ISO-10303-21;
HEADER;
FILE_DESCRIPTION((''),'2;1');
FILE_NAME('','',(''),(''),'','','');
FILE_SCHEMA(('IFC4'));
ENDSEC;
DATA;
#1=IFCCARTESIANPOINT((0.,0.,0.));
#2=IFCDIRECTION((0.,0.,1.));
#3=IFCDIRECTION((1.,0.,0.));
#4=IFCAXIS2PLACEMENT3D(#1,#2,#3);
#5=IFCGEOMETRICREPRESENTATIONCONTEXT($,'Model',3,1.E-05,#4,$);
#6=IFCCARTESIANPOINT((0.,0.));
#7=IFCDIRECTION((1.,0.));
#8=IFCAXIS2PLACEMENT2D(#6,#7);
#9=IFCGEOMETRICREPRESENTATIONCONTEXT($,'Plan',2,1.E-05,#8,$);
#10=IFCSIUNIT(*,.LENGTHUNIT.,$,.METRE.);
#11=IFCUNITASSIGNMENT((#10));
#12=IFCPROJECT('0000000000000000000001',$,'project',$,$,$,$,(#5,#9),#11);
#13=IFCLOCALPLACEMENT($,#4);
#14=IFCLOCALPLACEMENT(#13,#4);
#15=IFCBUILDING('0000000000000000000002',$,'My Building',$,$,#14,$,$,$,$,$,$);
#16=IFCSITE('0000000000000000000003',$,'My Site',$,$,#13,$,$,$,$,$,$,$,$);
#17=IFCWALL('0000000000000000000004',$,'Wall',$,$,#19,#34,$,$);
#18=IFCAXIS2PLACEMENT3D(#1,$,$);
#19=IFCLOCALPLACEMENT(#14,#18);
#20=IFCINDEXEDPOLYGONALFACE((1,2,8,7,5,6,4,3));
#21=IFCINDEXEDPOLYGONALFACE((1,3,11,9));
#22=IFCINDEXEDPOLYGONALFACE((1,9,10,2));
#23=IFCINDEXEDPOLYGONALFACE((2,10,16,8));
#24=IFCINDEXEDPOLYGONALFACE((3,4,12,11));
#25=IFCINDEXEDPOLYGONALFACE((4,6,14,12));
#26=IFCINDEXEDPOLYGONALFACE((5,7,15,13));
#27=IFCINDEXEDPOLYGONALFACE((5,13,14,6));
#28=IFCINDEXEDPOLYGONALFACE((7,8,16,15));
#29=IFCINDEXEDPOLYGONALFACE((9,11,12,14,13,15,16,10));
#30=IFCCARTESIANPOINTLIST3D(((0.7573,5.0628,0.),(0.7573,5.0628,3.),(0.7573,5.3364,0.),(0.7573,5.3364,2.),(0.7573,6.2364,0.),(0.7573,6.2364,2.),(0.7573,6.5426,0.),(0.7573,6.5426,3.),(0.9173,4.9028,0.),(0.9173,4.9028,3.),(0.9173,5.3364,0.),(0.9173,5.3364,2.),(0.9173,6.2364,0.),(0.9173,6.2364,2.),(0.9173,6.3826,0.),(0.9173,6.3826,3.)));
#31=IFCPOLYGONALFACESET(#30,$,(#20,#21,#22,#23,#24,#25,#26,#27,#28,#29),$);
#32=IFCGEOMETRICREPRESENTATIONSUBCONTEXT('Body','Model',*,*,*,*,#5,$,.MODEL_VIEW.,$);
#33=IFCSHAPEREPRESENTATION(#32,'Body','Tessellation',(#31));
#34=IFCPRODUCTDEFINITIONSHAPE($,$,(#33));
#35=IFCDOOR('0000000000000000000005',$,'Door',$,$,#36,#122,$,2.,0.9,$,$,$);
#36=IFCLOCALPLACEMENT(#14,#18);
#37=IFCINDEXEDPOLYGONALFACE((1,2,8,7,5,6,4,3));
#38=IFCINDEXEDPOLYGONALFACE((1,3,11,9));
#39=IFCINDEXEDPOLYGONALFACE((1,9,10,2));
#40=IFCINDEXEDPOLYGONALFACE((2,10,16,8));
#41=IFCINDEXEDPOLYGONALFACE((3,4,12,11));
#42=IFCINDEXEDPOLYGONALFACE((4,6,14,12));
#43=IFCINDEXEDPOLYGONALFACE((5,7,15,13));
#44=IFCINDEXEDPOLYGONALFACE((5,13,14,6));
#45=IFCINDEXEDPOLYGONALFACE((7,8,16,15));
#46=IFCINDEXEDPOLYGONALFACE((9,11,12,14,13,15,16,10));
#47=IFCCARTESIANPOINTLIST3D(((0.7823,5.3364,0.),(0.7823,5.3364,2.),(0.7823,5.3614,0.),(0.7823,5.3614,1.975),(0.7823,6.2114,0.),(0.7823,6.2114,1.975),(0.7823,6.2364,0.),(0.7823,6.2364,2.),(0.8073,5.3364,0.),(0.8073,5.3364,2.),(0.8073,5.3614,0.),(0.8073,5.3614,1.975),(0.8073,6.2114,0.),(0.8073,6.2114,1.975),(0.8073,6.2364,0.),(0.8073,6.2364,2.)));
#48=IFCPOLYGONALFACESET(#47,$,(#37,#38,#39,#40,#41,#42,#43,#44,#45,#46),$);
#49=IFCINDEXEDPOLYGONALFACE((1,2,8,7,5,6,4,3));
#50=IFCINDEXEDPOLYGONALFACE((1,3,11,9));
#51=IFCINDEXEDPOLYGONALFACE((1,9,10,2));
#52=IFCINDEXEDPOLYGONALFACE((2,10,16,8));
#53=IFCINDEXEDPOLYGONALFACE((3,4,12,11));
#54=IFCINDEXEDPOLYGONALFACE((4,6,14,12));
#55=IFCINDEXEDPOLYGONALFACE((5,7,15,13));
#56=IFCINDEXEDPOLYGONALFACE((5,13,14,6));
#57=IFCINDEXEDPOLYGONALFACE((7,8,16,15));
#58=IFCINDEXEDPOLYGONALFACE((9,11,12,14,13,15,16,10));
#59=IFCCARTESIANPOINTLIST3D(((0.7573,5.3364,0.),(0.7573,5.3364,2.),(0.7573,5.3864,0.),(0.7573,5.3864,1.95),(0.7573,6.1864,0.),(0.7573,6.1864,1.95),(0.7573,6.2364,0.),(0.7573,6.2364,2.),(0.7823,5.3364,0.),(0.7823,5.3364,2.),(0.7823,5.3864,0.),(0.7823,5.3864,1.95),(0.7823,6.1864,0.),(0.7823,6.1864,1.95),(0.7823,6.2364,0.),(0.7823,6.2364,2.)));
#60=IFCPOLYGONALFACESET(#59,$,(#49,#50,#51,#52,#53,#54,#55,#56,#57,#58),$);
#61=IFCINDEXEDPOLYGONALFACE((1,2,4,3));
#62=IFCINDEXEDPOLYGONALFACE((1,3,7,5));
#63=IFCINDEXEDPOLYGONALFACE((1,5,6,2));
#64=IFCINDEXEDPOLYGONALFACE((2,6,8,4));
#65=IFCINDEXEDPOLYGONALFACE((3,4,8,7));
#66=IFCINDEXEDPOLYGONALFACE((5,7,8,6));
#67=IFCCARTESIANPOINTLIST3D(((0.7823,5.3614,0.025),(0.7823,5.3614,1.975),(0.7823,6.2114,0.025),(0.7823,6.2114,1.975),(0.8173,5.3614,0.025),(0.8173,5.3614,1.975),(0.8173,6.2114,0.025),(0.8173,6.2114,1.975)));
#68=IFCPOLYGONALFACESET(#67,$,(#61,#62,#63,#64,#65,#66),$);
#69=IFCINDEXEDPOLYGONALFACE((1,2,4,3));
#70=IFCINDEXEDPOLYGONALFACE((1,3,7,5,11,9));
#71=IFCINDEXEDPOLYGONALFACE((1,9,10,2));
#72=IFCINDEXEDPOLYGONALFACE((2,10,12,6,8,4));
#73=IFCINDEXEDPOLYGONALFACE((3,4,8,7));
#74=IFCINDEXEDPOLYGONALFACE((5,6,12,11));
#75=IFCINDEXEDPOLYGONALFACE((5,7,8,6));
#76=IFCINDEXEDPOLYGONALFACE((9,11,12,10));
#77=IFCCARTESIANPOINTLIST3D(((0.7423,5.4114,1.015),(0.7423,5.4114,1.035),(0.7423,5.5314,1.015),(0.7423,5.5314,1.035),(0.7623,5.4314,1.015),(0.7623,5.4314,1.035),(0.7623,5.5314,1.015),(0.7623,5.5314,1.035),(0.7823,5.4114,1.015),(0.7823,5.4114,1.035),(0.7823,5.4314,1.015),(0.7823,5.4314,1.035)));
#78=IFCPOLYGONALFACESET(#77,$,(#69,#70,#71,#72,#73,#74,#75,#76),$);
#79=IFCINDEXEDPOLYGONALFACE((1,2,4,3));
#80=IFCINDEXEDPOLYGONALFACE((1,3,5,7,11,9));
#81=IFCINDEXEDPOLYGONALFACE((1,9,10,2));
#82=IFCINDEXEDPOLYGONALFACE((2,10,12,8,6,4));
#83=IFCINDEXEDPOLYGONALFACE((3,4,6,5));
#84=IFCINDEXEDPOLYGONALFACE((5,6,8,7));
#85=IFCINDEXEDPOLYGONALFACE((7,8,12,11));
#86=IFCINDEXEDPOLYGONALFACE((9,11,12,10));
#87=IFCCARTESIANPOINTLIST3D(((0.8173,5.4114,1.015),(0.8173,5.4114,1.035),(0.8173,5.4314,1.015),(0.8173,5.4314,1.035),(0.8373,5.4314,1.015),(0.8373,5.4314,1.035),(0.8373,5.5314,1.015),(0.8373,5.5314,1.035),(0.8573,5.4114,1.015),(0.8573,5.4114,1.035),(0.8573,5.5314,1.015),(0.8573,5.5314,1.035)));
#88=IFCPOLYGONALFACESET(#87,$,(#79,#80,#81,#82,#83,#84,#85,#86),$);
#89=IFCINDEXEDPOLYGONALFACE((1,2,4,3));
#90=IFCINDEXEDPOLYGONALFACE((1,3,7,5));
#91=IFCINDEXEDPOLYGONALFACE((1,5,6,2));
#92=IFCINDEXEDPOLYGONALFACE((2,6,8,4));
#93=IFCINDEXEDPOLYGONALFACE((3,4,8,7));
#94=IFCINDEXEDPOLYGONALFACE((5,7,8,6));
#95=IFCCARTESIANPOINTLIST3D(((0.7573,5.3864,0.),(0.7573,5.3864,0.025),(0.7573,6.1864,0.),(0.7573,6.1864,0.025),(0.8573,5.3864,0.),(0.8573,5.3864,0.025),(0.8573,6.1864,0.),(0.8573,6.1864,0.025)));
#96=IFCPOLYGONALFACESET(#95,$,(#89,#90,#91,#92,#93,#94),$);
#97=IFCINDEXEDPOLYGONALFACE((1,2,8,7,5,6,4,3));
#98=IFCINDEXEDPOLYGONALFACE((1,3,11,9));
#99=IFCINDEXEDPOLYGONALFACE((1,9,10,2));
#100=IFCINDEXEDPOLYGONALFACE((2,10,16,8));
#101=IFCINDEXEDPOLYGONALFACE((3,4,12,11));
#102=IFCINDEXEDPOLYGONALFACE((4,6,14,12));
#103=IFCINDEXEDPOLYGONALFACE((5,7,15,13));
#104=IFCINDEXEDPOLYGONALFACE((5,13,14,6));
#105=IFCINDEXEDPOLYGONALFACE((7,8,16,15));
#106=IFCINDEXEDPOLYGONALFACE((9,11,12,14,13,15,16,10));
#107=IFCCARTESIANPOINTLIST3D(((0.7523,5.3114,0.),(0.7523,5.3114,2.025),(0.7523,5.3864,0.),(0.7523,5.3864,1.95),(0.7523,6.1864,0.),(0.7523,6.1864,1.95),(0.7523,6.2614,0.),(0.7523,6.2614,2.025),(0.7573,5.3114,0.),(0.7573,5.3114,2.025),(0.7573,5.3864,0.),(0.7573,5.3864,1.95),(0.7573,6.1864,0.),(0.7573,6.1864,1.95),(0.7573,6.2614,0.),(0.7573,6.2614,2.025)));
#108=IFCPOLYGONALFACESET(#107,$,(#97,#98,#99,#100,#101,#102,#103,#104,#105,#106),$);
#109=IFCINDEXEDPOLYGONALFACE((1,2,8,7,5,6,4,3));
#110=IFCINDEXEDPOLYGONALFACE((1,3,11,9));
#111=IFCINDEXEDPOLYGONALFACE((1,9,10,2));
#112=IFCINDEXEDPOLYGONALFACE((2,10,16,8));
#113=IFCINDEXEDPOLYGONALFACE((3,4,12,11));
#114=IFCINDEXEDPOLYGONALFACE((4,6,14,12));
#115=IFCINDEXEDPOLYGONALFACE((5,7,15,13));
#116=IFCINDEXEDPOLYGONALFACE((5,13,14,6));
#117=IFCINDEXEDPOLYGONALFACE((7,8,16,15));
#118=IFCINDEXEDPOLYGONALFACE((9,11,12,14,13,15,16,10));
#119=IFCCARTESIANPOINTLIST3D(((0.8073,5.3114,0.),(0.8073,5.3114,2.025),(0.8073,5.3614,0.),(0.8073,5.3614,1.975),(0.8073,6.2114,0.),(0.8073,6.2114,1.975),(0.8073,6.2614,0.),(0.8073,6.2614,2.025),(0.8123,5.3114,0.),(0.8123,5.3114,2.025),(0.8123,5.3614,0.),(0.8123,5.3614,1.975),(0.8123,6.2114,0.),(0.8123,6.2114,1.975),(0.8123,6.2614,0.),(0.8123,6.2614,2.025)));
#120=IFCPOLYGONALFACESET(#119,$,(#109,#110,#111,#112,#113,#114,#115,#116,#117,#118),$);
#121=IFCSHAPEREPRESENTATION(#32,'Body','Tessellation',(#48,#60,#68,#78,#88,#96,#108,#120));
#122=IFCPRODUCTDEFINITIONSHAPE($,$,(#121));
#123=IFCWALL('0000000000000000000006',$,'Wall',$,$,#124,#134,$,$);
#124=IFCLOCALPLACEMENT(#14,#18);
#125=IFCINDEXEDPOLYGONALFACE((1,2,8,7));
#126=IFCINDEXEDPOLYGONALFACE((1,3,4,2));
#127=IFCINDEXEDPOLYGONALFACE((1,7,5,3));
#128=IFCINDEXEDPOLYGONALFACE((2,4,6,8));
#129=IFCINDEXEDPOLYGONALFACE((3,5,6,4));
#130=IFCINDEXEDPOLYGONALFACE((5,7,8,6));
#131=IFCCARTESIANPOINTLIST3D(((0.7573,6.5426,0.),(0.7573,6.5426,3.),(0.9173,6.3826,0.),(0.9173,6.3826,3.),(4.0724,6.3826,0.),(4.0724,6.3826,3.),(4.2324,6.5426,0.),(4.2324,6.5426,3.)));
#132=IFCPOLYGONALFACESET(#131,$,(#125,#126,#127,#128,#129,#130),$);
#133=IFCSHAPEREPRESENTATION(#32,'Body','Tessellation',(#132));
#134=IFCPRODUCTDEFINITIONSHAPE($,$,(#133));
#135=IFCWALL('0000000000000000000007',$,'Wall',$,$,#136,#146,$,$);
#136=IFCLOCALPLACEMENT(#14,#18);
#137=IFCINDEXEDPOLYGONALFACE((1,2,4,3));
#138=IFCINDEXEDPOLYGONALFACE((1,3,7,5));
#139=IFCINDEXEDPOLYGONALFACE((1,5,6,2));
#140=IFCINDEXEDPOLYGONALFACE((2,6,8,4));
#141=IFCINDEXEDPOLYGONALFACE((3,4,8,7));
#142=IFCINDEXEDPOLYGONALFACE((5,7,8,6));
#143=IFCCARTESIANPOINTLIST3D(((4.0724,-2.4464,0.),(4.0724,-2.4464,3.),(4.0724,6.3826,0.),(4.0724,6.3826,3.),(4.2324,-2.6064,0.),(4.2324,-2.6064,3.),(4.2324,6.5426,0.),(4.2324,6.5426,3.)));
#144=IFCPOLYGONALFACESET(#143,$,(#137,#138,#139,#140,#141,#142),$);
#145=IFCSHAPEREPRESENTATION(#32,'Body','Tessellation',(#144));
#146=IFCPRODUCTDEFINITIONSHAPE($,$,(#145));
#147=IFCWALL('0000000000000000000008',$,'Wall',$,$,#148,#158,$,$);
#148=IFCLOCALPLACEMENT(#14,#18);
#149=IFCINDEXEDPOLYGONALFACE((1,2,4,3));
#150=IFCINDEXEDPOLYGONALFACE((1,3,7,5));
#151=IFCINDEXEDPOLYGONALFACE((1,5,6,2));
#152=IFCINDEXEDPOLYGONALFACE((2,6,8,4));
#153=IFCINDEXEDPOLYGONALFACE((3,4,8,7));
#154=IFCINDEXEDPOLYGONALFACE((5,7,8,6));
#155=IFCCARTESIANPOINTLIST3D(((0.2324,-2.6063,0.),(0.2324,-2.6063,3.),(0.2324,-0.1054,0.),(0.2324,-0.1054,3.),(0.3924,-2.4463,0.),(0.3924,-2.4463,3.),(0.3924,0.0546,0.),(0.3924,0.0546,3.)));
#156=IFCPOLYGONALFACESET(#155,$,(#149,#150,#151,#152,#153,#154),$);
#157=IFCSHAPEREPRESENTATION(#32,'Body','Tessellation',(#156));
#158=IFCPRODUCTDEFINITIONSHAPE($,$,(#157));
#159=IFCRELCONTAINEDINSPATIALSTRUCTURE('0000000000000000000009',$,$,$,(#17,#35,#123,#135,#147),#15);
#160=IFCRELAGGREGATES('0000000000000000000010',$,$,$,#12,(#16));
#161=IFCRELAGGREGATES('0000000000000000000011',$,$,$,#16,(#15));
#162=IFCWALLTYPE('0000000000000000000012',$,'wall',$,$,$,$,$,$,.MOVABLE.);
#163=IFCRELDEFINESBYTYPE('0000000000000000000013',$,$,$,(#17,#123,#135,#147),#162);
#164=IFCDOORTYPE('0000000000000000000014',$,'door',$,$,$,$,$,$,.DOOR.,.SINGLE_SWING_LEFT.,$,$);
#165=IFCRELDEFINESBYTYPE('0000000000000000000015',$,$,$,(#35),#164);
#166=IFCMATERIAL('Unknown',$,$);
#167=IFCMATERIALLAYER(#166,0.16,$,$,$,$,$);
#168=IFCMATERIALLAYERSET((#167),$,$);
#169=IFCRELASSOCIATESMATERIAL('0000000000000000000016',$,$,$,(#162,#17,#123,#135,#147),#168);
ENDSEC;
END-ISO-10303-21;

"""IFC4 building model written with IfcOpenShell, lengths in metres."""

from ifc_helpers import new_model, entity, si_unit, frame, origin_with_axes, origin_2d_with_axis, place, context, subcontext, project, spatial, line, indexed_curve, outline, extrude, shape, source, transform, mapped, material, layer, layer_set, layer_usage, type_object, type_shapes, element, fill, save


model = new_model("IFC4")

# Units and contexts
model_context = context("Model", 3, precision=1e-05, world=origin_with_axes())
plan_context = context("Plan", 2, precision=1e-05, world=origin_2d_with_axis())
body_context_1 = subcontext(model_context, "Body", "Model", "MODEL_VIEW")
body_context_2 = subcontext(plan_context, "Body", "Plan", "PLAN_VIEW")
ifc_project = project(units=[si_unit("LENGTHUNIT", "METRE")], contexts=[model_context, plan_context])

# Site, building
site_placement = place(None, origin_with_axes())
site = spatial("IfcSite", under=ifc_project, at=site_placement, Name="My Site")
building_placement = place(site_placement, origin_with_axes())
building = spatial("IfcBuilding", under=site, at=building_placement, Name="My Building")

# Shared definitions
ifc_material = material(Name="Unknown")

# Shared definitions
ifc_layer_1 = layer(ifc_material, 0.16)
ifc_layer_set_1 = layer_set([ifc_layer_1])
wall_type_1 = type_object("IfcWallType", Name="wall", PredefinedType="MOVABLE", material=ifc_layer_set_1)

# Wall, opening, door
ifc_layer_usage_1 = layer_usage(ifc_layer_set_1, "AXIS2", "POSITIVE", 0.0)
wall_1_placement = place(building_placement, frame((0.9173, 4.9028, 0.0), z_axis=(0.0, 0.0, 1.0), x_axis=(0.0, 1.0, 0.0)))
wall_1 = element("IfcWall", 1, at=wall_1_placement, inside=building, type_object=wall_type_1, material=ifc_layer_usage_1, Name="Wall", context=body_context_1, shape_type="SweptSolid", body=[
    extrude(outline(indexed_curve([(0.0, 0.0), (0.16, 0.16), (1.6398, 0.16), (1.4798, 0.0)], segments=[line(1, 2, 3, 4, 1)])), origin_with_axes(), (0.0, 0.0, 1.0), 3.0),
])
shared_shape_1 = source(origin_with_axes(), body_context_1, "Body", "SweptSolid", [
    extrude(outline(indexed_curve([(0.0, 0.0), (0.9, 0.0), (0.9, 2.0), (0.0, 2.0)], segments=[line(1, 2, 3, 4, 1)])), frame((0.0, -0.6, 0.0), z_axis=(0.0, -1.0, 0.0), x_axis=(1.0, 0.0, 0.0)), (0.0, 0.0, -1.0), 1.2),
])
opening_1_placement = place(wall_1_placement, frame((1.3336, 0.16, 0.0), z_axis=(0.0, 0.0, 1.0), x_axis=(-1.0, 0.0, 0.0)))
opening_1 = element("IfcOpeningElement", 2, at=opening_1_placement, cuts=wall_1, PredefinedType="OPENING", context=body_context_1, shape_type="MappedRepresentation", body=[
    mapped(shared_shape_1, transform((0.0, 0.0, 0.0), x_axis=(1.0, 0.0, 0.0), y_axis=(0.0, 1.0, 0.0), z_axis=(0.0, 0.0, 1.0), scale=1.0)),
])
door_type = type_object("IfcDoorType", Name="door", OperationType="SINGLE_SWING_LEFT", PredefinedType="DOOR")
shared_shape_2 = source(origin_with_axes(), body_context_1, "Body", "SweptSolid", [
    extrude(outline(indexed_curve([(0.0, 0.0), (0.0, 2.0), (0.9, 2.0), (0.9, 0.0), (0.875, 0.0), (0.875, 1.975), (0.025, 1.975), (0.025, 0.0)], segments=[line(1, 2, 3, 4, 5, 6, 7, 8, 1)])), frame((0.0, 0.025, 0.0), z_axis=(0.0, -1.0, 0.0), x_axis=(1.0, 0.0, 0.0)), (0.0, 0.0, -1.0), 0.025),
    extrude(outline(indexed_curve([(0.0, 0.0), (0.0, 2.0), (0.9, 2.0), (0.9, 0.0), (0.85, 0.0), (0.85, 1.95), (0.05, 1.95), (0.05, 0.0)], segments=[line(1, 2, 3, 4, 5, 6, 7, 8, 1)])), frame((0.0, 0.0, 0.0), z_axis=(0.0, -1.0, 0.0), x_axis=(1.0, 0.0, 0.0)), (0.0, 0.0, -1.0), 0.025),
    extrude(outline(indexed_curve([(0.0, 0.0), (0.85, 0.0), (0.85, 0.035), (0.0, 0.035)], segments=[line(1, 2, 3, 4, 1)])), frame((0.025, 0.025, 0.025), z_axis=(0.0, 0.0, 1.0), x_axis=(1.0, 0.0, 0.0)), (0.0, 0.0, 1.0), 1.95),
    extrude(outline(indexed_curve([(0.0, 0.0), (0.0, -0.04), (-0.12, -0.04), (-0.12, -0.02), (-0.02, -0.02), (-0.02, 0.0)], segments=[line(1, 2, 3, 4, 5, 6, 1)])), frame((0.825, 0.025, 1.015), z_axis=(0.0, 0.0, 1.0), x_axis=(1.0, 0.0, 0.0)), (0.0, 0.0, 1.0), 0.02),
    extrude(outline(indexed_curve([(0.0, 0.0), (0.0, 0.04), (-0.12, 0.04), (-0.12, 0.02), (-0.02, 0.02), (-0.02, 0.0)], segments=[line(1, 2, 3, 4, 5, 6, 1)])), frame((0.825, 0.06, 1.015), z_axis=(0.0, 0.0, 1.0), x_axis=(1.0, 0.0, 0.0)), (0.0, 0.0, 1.0), 0.02),
    extrude(outline(indexed_curve([(0.0, 0.0), (0.8, 0.0), (0.8, 0.1), (0.0, 0.1)], segments=[line(1, 2, 3, 4, 1)])), frame((0.05, 0.0, 0.0), z_axis=(0.0, 0.0, 1.0), x_axis=(1.0, 0.0, 0.0)), (0.0, 0.0, 1.0), 0.025),
    extrude(outline(indexed_curve([(0.0, 0.0), (0.0, 2.025), (0.95, 2.025), (0.95, 0.0), (0.875, 0.0), (0.875, 1.95), (0.075, 1.95), (0.075, 0.0)], segments=[line(1, 2, 3, 4, 5, 6, 7, 8, 1)])), frame((-0.025, -0.005, 0.0), z_axis=(0.0, -1.0, 0.0), x_axis=(1.0, 0.0, 0.0)), (0.0, 0.0, -1.0), 0.005),
    extrude(outline(indexed_curve([(0.0, 0.0), (0.0, 2.025), (0.95, 2.025), (0.95, 0.0), (0.9, 0.0), (0.9, 1.975), (0.05, 1.975), (0.05, 0.0)], segments=[line(1, 2, 3, 4, 5, 6, 7, 8, 1)])), frame((-0.025, 0.05, 0.0), z_axis=(0.0, -1.0, 0.0), x_axis=(1.0, 0.0, 0.0)), (0.0, 0.0, -1.0), 0.005),
])
shared_shape_3 = source(origin_with_axes(), body_context_2, "Body", "Curve2D", [
    entity("IfcIndexedPolyCurve", entity("IfcCartesianPointList2D", [[0.0, 0.0], [0.0, 0.05], [0.025, 0.05], [0.025, 0.025], [0.05, 0.025], [0.05, 0.0]]), [entity("IfcLineIndex", [1, 2, 3, 4, 5, 6, 1])]),
    entity("IfcIndexedPolyCurve", entity("IfcCartesianPointList2D", [[0.9, 0.0], [0.9, 0.05], [0.875, 0.05], [0.875, 0.025], [0.85, 0.025], [0.85, 0.0]]), [entity("IfcLineIndex", [1, 2, 3, 4, 5, 6, 1])]),
    entity("IfcTrimmedCurve", entity("IfcEllipse", entity("IfcAxis2Placement2D", entity("IfcCartesianPoint", [0.06, 0.05]), entity("IfcDirection", [1.0, 0.0])), 0.815, 0.85), [entity("IfcCartesianPoint", [0.875, 0.05])], [entity("IfcCartesianPoint", [0.06, 0.9])], True, "CARTESIAN"),
    entity("IfcIndexedPolyCurve", entity("IfcCartesianPointList2D", [[0.025, 0.05], [0.06, 0.05], [0.06, 0.9], [0.025, 0.9]]), [entity("IfcLineIndex", [1, 2, 3, 4, 1])]),
])
type_shapes(door_type, [shared_shape_2, shared_shape_3])
door_1_placement = place(opening_1_placement, frame((0.0, 0.0, 0.0), z_axis=(0.0, 0.0, 1.0), x_axis=(1.0, 0.0, 0.0)))
door_1 = element("IfcDoor", 3, at=door_1_placement, inside=building, type_object=door_type, Name="Door", OverallHeight=2.0, OverallWidth=0.9, shapes=[
    shape(body_context_1, "Body", "MappedRepresentation", [mapped(shared_shape_2, transform((0.0, 0.0, 0.0), x_axis=(1.0, 0.0, 0.0), y_axis=(0.0, 1.0, 0.0), z_axis=(0.0, 0.0, 1.0), scale=1.0))]),
    shape(body_context_2, "Body", "MappedRepresentation", [mapped(shared_shape_3, transform((0.0, 0.0, 0.0), x_axis=(1.0, 0.0, 0.0), y_axis=(0.0, 1.0, 0.0), z_axis=(0.0, 0.0, 1.0), scale=1.0))]),
])
fill(opening_1, door_1)

# Walls
ifc_layer_usage_2 = layer_usage(ifc_layer_set_1, "AXIS2", "POSITIVE", 0.0)
wall_2_placement = place(building_placement, frame((0.9173, 6.3826, 0.0), z_axis=(0.0, 0.0, 1.0), x_axis=(1.0, 0.0, 0.0)))
element("IfcWall", 4, at=wall_2_placement, inside=building, type_object=wall_type_1, material=ifc_layer_usage_2, Name="Wall", context=body_context_1, shape_type="SweptSolid", body=[
    extrude(outline(indexed_curve([(0.0, 0.0), (-0.16, 0.16), (3.3151, 0.16), (3.1551, 0.0)], segments=[line(1, 2, 3, 4, 1)])), origin_with_axes(), (0.0, 0.0, 1.0), 3.0),
])
ifc_layer_usage_3 = layer_usage(ifc_layer_set_1, "AXIS2", "POSITIVE", 0.0)
wall_3_placement = place(building_placement, frame((4.0724, 6.3826, 0.0), z_axis=(0.0, 0.0, 1.0), x_axis=(0.0, -1.0, 0.0)))
element("IfcWall", 5, at=wall_3_placement, inside=building, type_object=wall_type_1, material=ifc_layer_usage_3, Name="Wall", context=body_context_1, shape_type="SweptSolid", body=[
    extrude(outline(indexed_curve([(0.0, 0.0), (-0.16, 0.16), (8.989, 0.16), (8.829, 0.0)], segments=[line(1, 2, 3, 4, 1)])), origin_with_axes(), (0.0, 0.0, 1.0), 3.0),
])

# Wall
ifc_layer_usage_4 = layer_usage(ifc_layer_set_1, "AXIS2", "POSITIVE", 0.0)
wall_4_placement = place(building_placement, frame((0.3924, -2.4463, 0.0), z_axis=(0.0, 0.0, 1.0), x_axis=(0.0, 1.0, 0.0)))
element("IfcWall", 6, at=wall_4_placement, inside=building, type_object=wall_type_1, material=ifc_layer_usage_4, Name="Wall", context=body_context_1, shape_type="SweptSolid", body=[
    extrude(outline(indexed_curve([(0.0, 0.0), (-0.16, 0.16), (2.3409, 0.16), (2.5009, 0.0)], segments=[line(1, 2, 3, 4, 1)])), origin_with_axes(), (0.0, 0.0, 1.0), 3.0),
])

save(model, "model.ifc")
